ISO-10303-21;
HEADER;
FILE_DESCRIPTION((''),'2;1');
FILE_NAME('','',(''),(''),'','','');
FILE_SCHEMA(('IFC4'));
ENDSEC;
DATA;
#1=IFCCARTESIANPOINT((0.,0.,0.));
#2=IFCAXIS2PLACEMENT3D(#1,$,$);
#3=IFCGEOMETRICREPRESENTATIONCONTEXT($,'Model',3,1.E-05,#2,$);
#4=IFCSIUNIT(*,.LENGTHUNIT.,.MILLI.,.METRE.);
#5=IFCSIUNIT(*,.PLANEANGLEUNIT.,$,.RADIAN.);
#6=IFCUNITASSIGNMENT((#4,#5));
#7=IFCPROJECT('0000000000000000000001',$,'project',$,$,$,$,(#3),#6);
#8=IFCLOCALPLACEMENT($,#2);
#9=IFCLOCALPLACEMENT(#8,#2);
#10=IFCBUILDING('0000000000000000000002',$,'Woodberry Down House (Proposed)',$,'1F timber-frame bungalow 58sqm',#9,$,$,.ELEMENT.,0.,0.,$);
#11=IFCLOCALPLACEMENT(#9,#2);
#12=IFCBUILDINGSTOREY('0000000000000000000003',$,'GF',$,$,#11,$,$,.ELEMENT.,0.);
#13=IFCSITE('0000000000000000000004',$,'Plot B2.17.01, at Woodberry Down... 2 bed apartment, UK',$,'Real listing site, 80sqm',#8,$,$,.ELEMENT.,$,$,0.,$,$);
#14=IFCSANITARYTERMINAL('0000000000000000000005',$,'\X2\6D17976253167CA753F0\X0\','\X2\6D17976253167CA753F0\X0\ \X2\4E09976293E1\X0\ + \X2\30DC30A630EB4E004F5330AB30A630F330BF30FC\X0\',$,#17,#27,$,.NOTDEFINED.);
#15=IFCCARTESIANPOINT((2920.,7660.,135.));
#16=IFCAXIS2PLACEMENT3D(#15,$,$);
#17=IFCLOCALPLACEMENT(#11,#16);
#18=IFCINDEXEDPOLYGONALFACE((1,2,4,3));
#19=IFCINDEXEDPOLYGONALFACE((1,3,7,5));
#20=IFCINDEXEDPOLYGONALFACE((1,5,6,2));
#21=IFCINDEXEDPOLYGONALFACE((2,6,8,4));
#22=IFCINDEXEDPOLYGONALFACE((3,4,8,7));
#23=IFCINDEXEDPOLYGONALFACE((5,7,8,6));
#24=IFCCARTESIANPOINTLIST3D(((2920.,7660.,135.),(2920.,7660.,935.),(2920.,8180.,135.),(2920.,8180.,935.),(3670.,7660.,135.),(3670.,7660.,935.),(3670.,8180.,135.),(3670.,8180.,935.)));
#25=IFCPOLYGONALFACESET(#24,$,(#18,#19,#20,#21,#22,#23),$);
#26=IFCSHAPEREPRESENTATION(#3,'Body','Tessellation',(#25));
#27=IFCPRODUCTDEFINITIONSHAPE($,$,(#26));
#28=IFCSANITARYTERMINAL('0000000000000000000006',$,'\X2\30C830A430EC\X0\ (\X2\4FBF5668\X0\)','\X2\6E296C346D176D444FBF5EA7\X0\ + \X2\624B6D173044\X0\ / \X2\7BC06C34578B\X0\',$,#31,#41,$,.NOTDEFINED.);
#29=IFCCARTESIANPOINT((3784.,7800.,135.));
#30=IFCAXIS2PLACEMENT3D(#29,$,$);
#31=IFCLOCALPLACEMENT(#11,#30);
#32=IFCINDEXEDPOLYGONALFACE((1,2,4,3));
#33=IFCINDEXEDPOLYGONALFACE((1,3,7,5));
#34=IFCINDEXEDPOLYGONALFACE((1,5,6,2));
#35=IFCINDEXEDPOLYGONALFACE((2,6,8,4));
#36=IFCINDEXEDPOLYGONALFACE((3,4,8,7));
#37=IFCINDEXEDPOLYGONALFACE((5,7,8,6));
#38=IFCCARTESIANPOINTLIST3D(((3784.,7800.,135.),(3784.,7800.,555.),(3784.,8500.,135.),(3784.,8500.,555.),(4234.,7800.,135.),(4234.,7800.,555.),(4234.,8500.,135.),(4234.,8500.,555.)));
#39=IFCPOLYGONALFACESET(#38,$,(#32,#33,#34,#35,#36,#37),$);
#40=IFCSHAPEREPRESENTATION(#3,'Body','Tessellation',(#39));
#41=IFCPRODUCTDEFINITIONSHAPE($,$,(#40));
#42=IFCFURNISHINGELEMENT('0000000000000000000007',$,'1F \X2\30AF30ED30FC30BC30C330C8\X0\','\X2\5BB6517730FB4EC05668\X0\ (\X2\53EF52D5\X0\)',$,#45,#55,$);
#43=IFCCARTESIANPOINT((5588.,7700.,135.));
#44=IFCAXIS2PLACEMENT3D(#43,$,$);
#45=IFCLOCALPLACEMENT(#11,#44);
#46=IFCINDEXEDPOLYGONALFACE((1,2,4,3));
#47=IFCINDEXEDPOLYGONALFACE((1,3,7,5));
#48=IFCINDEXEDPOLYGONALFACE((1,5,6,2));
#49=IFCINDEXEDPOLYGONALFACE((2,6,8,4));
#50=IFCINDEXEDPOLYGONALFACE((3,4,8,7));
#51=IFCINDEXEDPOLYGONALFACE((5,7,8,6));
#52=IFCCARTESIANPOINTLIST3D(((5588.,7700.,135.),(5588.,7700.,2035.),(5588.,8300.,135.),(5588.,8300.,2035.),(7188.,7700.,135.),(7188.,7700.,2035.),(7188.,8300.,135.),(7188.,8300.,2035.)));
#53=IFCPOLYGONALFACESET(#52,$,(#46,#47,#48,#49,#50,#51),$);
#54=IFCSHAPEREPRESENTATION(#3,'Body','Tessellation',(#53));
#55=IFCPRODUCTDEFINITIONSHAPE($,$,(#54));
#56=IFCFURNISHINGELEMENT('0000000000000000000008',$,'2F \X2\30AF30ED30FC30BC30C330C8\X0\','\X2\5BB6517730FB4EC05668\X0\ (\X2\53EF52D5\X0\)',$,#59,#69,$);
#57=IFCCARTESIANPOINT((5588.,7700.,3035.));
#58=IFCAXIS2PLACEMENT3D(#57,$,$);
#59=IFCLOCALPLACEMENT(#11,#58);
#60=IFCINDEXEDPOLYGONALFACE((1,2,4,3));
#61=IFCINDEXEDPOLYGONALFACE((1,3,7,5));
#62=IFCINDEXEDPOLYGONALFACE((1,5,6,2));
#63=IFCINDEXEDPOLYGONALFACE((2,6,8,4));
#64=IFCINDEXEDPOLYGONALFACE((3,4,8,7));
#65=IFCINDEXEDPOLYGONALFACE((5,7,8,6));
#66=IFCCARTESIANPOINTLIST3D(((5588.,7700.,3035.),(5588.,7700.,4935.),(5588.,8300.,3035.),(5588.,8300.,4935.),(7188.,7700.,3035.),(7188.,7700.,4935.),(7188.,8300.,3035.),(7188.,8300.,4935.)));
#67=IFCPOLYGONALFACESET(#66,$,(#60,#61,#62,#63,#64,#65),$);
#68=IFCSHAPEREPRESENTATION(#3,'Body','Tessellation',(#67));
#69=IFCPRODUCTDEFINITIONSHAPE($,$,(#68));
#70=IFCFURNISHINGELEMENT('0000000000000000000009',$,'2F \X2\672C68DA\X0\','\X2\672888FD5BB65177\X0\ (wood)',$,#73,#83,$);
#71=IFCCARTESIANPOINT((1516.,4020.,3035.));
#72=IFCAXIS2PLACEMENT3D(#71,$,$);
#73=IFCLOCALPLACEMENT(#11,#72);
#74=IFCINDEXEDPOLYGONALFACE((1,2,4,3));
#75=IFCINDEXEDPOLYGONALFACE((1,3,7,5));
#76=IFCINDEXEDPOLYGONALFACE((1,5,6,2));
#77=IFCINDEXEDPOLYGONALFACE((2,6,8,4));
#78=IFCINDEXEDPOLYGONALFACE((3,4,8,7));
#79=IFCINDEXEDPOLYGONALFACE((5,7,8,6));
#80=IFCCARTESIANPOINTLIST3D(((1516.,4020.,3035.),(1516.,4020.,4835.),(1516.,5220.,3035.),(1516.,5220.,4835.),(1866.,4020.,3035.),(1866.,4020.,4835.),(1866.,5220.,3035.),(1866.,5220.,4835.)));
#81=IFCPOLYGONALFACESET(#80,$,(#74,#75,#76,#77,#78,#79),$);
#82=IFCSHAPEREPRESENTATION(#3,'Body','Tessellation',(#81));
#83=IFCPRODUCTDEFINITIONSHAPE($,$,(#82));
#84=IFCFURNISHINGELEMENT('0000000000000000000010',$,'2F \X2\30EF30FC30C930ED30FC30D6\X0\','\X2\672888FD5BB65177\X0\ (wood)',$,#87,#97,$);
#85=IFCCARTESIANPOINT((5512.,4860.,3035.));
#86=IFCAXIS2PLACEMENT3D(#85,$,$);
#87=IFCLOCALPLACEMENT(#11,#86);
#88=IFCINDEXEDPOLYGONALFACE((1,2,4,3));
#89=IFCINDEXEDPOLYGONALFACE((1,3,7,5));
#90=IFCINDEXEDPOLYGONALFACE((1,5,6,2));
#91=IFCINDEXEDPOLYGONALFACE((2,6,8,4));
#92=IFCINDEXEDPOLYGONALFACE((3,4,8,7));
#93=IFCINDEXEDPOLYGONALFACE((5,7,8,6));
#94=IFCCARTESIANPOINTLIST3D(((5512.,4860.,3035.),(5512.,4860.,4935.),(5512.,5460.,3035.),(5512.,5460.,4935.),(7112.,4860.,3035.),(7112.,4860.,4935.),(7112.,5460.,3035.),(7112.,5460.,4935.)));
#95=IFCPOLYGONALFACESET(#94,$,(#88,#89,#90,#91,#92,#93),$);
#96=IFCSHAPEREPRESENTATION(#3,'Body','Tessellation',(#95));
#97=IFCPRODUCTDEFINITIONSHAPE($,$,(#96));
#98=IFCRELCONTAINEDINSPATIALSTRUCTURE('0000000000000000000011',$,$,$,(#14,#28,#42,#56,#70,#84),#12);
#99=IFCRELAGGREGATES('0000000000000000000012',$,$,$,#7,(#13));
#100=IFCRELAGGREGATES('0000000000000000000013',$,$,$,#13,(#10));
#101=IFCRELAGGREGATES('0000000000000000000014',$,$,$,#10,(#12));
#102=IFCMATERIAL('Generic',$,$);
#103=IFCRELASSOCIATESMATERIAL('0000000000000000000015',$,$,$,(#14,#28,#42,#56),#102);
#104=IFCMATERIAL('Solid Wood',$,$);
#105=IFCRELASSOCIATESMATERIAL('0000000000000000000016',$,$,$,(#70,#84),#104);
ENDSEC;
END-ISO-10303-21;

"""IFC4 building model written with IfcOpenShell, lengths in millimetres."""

from ifc_helpers import new_model, si_unit, frame, frame_2d, origin, place, context, project, spatial, rectangle, extrude, material, element, save


model = new_model("IFC4")

# Units and contexts
model_context = context("Model", 3, precision=1e-05, world=origin())
ifc_project = project(units=[si_unit("LENGTHUNIT", "METRE", prefix="MILLI"), si_unit("PLANEANGLEUNIT", "RADIAN")], contexts=[model_context])

# Site, building, storey
site_placement = place(None, origin())
site = spatial("IfcSite", under=ifc_project, at=site_placement, Name="Plot B2.17.01, at Woodberry Down... 2 bed apartment, UK", ObjectType="Real listing site, 80sqm", CompositionType="ELEMENT", RefElevation=0.0)
building_placement = place(site_placement, origin())
building = spatial("IfcBuilding", under=site, at=building_placement, Name="Woodberry Down House (Proposed)", ObjectType="1F timber-frame bungalow 58sqm", CompositionType="ELEMENT", ElevationOfRefHeight=0.0, ElevationOfTerrain=0.0)
storey_placement = place(building_placement, origin())
storey = spatial("IfcBuildingStorey", under=building, at=storey_placement, Name="GF", CompositionType="ELEMENT", Elevation=0.0)

# Shared definitions
ifc_material_1 = material(Name="Solid Wood")

# Shared definitions
ifc_material_2 = material(Name="Generic")

# Sanitary terminals
sanitary_terminal_1_placement = place(storey_placement, frame((2920.0, 7660.0, 135.0)))
element("IfcSanitaryTerminal", 1, at=sanitary_terminal_1_placement, inside=storey, material=ifc_material_2, Name="洗面化粧台", Description="洗面化粧台 三面鏡 + ボウル一体カウンター", PredefinedType="NOTDEFINED", context=model_context, shape_type="SweptSolid", body=[
    extrude(rectangle(XDim=750.0, YDim=520.0, at=frame_2d((375.0, 260.0))), frame((2920.0, 7660.0, 135.0)), (0.0, 0.0, 1.0), 800.0),
])
sanitary_terminal_2_placement = place(storey_placement, frame((3784.0, 7800.0, 135.0)))
element("IfcSanitaryTerminal", 2, at=sanitary_terminal_2_placement, inside=storey, material=ifc_material_2, Name="トイレ (便器)", Description="温水洗浄便座 + 手洗い / 節水型", PredefinedType="NOTDEFINED", context=model_context, shape_type="SweptSolid", body=[
    extrude(rectangle(XDim=450.0, YDim=700.0, at=frame_2d((225.0, 350.0))), frame((3784.0, 7800.0, 135.0)), (0.0, 0.0, 1.0), 420.0),
])

# Furnishing elements
furnishing_1_placement = place(storey_placement, frame((5588.0, 7700.0, 135.0)))
element("IfcFurnishingElement", 3, at=furnishing_1_placement, inside=storey, material=ifc_material_2, Name="1F クローゼット", Description="家具・什器 (可動)", context=model_context, shape_type="SweptSolid", body=[
    extrude(rectangle(XDim=1600.0, YDim=600.0, at=frame_2d((800.0, 300.0))), frame((5588.0, 7700.0, 135.0)), (0.0, 0.0, 1.0), 1900.0),
])
furnishing_2_placement = place(storey_placement, frame((5588.0, 7700.0, 3035.0)))
element("IfcFurnishingElement", 4, at=furnishing_2_placement, inside=storey, material=ifc_material_2, Name="2F クローゼット", Description="家具・什器 (可動)", context=model_context, shape_type="SweptSolid", body=[
    extrude(rectangle(XDim=1600.0, YDim=600.0, at=frame_2d((800.0, 300.0))), frame((5588.0, 7700.0, 3035.0)), (0.0, 0.0, 1.0), 1900.0),
])
furnishing_3_placement = place(storey_placement, frame((1516.0, 4020.0, 3035.0)))
element("IfcFurnishingElement", 5, at=furnishing_3_placement, inside=storey, material=ifc_material_1, Name="2F 本棚", Description="木製家具 (wood)", context=model_context, shape_type="SweptSolid", body=[
    extrude(rectangle(XDim=350.0, YDim=1200.0, at=frame_2d((175.0, 600.0))), frame((1516.0, 4020.0, 3035.0)), (0.0, 0.0, 1.0), 1800.0),
])
furnishing_4_placement = place(storey_placement, frame((5512.0, 4860.0, 3035.0)))
element("IfcFurnishingElement", 6, at=furnishing_4_placement, inside=storey, material=ifc_material_1, Name="2F ワードローブ", Description="木製家具 (wood)", context=model_context, shape_type="SweptSolid", body=[
    extrude(rectangle(XDim=1600.0, YDim=600.0, at=frame_2d((800.0, 300.0))), frame((5512.0, 4860.0, 3035.0)), (0.0, 0.0, 1.0), 1900.0),
])

save(model, "model.ifc")
